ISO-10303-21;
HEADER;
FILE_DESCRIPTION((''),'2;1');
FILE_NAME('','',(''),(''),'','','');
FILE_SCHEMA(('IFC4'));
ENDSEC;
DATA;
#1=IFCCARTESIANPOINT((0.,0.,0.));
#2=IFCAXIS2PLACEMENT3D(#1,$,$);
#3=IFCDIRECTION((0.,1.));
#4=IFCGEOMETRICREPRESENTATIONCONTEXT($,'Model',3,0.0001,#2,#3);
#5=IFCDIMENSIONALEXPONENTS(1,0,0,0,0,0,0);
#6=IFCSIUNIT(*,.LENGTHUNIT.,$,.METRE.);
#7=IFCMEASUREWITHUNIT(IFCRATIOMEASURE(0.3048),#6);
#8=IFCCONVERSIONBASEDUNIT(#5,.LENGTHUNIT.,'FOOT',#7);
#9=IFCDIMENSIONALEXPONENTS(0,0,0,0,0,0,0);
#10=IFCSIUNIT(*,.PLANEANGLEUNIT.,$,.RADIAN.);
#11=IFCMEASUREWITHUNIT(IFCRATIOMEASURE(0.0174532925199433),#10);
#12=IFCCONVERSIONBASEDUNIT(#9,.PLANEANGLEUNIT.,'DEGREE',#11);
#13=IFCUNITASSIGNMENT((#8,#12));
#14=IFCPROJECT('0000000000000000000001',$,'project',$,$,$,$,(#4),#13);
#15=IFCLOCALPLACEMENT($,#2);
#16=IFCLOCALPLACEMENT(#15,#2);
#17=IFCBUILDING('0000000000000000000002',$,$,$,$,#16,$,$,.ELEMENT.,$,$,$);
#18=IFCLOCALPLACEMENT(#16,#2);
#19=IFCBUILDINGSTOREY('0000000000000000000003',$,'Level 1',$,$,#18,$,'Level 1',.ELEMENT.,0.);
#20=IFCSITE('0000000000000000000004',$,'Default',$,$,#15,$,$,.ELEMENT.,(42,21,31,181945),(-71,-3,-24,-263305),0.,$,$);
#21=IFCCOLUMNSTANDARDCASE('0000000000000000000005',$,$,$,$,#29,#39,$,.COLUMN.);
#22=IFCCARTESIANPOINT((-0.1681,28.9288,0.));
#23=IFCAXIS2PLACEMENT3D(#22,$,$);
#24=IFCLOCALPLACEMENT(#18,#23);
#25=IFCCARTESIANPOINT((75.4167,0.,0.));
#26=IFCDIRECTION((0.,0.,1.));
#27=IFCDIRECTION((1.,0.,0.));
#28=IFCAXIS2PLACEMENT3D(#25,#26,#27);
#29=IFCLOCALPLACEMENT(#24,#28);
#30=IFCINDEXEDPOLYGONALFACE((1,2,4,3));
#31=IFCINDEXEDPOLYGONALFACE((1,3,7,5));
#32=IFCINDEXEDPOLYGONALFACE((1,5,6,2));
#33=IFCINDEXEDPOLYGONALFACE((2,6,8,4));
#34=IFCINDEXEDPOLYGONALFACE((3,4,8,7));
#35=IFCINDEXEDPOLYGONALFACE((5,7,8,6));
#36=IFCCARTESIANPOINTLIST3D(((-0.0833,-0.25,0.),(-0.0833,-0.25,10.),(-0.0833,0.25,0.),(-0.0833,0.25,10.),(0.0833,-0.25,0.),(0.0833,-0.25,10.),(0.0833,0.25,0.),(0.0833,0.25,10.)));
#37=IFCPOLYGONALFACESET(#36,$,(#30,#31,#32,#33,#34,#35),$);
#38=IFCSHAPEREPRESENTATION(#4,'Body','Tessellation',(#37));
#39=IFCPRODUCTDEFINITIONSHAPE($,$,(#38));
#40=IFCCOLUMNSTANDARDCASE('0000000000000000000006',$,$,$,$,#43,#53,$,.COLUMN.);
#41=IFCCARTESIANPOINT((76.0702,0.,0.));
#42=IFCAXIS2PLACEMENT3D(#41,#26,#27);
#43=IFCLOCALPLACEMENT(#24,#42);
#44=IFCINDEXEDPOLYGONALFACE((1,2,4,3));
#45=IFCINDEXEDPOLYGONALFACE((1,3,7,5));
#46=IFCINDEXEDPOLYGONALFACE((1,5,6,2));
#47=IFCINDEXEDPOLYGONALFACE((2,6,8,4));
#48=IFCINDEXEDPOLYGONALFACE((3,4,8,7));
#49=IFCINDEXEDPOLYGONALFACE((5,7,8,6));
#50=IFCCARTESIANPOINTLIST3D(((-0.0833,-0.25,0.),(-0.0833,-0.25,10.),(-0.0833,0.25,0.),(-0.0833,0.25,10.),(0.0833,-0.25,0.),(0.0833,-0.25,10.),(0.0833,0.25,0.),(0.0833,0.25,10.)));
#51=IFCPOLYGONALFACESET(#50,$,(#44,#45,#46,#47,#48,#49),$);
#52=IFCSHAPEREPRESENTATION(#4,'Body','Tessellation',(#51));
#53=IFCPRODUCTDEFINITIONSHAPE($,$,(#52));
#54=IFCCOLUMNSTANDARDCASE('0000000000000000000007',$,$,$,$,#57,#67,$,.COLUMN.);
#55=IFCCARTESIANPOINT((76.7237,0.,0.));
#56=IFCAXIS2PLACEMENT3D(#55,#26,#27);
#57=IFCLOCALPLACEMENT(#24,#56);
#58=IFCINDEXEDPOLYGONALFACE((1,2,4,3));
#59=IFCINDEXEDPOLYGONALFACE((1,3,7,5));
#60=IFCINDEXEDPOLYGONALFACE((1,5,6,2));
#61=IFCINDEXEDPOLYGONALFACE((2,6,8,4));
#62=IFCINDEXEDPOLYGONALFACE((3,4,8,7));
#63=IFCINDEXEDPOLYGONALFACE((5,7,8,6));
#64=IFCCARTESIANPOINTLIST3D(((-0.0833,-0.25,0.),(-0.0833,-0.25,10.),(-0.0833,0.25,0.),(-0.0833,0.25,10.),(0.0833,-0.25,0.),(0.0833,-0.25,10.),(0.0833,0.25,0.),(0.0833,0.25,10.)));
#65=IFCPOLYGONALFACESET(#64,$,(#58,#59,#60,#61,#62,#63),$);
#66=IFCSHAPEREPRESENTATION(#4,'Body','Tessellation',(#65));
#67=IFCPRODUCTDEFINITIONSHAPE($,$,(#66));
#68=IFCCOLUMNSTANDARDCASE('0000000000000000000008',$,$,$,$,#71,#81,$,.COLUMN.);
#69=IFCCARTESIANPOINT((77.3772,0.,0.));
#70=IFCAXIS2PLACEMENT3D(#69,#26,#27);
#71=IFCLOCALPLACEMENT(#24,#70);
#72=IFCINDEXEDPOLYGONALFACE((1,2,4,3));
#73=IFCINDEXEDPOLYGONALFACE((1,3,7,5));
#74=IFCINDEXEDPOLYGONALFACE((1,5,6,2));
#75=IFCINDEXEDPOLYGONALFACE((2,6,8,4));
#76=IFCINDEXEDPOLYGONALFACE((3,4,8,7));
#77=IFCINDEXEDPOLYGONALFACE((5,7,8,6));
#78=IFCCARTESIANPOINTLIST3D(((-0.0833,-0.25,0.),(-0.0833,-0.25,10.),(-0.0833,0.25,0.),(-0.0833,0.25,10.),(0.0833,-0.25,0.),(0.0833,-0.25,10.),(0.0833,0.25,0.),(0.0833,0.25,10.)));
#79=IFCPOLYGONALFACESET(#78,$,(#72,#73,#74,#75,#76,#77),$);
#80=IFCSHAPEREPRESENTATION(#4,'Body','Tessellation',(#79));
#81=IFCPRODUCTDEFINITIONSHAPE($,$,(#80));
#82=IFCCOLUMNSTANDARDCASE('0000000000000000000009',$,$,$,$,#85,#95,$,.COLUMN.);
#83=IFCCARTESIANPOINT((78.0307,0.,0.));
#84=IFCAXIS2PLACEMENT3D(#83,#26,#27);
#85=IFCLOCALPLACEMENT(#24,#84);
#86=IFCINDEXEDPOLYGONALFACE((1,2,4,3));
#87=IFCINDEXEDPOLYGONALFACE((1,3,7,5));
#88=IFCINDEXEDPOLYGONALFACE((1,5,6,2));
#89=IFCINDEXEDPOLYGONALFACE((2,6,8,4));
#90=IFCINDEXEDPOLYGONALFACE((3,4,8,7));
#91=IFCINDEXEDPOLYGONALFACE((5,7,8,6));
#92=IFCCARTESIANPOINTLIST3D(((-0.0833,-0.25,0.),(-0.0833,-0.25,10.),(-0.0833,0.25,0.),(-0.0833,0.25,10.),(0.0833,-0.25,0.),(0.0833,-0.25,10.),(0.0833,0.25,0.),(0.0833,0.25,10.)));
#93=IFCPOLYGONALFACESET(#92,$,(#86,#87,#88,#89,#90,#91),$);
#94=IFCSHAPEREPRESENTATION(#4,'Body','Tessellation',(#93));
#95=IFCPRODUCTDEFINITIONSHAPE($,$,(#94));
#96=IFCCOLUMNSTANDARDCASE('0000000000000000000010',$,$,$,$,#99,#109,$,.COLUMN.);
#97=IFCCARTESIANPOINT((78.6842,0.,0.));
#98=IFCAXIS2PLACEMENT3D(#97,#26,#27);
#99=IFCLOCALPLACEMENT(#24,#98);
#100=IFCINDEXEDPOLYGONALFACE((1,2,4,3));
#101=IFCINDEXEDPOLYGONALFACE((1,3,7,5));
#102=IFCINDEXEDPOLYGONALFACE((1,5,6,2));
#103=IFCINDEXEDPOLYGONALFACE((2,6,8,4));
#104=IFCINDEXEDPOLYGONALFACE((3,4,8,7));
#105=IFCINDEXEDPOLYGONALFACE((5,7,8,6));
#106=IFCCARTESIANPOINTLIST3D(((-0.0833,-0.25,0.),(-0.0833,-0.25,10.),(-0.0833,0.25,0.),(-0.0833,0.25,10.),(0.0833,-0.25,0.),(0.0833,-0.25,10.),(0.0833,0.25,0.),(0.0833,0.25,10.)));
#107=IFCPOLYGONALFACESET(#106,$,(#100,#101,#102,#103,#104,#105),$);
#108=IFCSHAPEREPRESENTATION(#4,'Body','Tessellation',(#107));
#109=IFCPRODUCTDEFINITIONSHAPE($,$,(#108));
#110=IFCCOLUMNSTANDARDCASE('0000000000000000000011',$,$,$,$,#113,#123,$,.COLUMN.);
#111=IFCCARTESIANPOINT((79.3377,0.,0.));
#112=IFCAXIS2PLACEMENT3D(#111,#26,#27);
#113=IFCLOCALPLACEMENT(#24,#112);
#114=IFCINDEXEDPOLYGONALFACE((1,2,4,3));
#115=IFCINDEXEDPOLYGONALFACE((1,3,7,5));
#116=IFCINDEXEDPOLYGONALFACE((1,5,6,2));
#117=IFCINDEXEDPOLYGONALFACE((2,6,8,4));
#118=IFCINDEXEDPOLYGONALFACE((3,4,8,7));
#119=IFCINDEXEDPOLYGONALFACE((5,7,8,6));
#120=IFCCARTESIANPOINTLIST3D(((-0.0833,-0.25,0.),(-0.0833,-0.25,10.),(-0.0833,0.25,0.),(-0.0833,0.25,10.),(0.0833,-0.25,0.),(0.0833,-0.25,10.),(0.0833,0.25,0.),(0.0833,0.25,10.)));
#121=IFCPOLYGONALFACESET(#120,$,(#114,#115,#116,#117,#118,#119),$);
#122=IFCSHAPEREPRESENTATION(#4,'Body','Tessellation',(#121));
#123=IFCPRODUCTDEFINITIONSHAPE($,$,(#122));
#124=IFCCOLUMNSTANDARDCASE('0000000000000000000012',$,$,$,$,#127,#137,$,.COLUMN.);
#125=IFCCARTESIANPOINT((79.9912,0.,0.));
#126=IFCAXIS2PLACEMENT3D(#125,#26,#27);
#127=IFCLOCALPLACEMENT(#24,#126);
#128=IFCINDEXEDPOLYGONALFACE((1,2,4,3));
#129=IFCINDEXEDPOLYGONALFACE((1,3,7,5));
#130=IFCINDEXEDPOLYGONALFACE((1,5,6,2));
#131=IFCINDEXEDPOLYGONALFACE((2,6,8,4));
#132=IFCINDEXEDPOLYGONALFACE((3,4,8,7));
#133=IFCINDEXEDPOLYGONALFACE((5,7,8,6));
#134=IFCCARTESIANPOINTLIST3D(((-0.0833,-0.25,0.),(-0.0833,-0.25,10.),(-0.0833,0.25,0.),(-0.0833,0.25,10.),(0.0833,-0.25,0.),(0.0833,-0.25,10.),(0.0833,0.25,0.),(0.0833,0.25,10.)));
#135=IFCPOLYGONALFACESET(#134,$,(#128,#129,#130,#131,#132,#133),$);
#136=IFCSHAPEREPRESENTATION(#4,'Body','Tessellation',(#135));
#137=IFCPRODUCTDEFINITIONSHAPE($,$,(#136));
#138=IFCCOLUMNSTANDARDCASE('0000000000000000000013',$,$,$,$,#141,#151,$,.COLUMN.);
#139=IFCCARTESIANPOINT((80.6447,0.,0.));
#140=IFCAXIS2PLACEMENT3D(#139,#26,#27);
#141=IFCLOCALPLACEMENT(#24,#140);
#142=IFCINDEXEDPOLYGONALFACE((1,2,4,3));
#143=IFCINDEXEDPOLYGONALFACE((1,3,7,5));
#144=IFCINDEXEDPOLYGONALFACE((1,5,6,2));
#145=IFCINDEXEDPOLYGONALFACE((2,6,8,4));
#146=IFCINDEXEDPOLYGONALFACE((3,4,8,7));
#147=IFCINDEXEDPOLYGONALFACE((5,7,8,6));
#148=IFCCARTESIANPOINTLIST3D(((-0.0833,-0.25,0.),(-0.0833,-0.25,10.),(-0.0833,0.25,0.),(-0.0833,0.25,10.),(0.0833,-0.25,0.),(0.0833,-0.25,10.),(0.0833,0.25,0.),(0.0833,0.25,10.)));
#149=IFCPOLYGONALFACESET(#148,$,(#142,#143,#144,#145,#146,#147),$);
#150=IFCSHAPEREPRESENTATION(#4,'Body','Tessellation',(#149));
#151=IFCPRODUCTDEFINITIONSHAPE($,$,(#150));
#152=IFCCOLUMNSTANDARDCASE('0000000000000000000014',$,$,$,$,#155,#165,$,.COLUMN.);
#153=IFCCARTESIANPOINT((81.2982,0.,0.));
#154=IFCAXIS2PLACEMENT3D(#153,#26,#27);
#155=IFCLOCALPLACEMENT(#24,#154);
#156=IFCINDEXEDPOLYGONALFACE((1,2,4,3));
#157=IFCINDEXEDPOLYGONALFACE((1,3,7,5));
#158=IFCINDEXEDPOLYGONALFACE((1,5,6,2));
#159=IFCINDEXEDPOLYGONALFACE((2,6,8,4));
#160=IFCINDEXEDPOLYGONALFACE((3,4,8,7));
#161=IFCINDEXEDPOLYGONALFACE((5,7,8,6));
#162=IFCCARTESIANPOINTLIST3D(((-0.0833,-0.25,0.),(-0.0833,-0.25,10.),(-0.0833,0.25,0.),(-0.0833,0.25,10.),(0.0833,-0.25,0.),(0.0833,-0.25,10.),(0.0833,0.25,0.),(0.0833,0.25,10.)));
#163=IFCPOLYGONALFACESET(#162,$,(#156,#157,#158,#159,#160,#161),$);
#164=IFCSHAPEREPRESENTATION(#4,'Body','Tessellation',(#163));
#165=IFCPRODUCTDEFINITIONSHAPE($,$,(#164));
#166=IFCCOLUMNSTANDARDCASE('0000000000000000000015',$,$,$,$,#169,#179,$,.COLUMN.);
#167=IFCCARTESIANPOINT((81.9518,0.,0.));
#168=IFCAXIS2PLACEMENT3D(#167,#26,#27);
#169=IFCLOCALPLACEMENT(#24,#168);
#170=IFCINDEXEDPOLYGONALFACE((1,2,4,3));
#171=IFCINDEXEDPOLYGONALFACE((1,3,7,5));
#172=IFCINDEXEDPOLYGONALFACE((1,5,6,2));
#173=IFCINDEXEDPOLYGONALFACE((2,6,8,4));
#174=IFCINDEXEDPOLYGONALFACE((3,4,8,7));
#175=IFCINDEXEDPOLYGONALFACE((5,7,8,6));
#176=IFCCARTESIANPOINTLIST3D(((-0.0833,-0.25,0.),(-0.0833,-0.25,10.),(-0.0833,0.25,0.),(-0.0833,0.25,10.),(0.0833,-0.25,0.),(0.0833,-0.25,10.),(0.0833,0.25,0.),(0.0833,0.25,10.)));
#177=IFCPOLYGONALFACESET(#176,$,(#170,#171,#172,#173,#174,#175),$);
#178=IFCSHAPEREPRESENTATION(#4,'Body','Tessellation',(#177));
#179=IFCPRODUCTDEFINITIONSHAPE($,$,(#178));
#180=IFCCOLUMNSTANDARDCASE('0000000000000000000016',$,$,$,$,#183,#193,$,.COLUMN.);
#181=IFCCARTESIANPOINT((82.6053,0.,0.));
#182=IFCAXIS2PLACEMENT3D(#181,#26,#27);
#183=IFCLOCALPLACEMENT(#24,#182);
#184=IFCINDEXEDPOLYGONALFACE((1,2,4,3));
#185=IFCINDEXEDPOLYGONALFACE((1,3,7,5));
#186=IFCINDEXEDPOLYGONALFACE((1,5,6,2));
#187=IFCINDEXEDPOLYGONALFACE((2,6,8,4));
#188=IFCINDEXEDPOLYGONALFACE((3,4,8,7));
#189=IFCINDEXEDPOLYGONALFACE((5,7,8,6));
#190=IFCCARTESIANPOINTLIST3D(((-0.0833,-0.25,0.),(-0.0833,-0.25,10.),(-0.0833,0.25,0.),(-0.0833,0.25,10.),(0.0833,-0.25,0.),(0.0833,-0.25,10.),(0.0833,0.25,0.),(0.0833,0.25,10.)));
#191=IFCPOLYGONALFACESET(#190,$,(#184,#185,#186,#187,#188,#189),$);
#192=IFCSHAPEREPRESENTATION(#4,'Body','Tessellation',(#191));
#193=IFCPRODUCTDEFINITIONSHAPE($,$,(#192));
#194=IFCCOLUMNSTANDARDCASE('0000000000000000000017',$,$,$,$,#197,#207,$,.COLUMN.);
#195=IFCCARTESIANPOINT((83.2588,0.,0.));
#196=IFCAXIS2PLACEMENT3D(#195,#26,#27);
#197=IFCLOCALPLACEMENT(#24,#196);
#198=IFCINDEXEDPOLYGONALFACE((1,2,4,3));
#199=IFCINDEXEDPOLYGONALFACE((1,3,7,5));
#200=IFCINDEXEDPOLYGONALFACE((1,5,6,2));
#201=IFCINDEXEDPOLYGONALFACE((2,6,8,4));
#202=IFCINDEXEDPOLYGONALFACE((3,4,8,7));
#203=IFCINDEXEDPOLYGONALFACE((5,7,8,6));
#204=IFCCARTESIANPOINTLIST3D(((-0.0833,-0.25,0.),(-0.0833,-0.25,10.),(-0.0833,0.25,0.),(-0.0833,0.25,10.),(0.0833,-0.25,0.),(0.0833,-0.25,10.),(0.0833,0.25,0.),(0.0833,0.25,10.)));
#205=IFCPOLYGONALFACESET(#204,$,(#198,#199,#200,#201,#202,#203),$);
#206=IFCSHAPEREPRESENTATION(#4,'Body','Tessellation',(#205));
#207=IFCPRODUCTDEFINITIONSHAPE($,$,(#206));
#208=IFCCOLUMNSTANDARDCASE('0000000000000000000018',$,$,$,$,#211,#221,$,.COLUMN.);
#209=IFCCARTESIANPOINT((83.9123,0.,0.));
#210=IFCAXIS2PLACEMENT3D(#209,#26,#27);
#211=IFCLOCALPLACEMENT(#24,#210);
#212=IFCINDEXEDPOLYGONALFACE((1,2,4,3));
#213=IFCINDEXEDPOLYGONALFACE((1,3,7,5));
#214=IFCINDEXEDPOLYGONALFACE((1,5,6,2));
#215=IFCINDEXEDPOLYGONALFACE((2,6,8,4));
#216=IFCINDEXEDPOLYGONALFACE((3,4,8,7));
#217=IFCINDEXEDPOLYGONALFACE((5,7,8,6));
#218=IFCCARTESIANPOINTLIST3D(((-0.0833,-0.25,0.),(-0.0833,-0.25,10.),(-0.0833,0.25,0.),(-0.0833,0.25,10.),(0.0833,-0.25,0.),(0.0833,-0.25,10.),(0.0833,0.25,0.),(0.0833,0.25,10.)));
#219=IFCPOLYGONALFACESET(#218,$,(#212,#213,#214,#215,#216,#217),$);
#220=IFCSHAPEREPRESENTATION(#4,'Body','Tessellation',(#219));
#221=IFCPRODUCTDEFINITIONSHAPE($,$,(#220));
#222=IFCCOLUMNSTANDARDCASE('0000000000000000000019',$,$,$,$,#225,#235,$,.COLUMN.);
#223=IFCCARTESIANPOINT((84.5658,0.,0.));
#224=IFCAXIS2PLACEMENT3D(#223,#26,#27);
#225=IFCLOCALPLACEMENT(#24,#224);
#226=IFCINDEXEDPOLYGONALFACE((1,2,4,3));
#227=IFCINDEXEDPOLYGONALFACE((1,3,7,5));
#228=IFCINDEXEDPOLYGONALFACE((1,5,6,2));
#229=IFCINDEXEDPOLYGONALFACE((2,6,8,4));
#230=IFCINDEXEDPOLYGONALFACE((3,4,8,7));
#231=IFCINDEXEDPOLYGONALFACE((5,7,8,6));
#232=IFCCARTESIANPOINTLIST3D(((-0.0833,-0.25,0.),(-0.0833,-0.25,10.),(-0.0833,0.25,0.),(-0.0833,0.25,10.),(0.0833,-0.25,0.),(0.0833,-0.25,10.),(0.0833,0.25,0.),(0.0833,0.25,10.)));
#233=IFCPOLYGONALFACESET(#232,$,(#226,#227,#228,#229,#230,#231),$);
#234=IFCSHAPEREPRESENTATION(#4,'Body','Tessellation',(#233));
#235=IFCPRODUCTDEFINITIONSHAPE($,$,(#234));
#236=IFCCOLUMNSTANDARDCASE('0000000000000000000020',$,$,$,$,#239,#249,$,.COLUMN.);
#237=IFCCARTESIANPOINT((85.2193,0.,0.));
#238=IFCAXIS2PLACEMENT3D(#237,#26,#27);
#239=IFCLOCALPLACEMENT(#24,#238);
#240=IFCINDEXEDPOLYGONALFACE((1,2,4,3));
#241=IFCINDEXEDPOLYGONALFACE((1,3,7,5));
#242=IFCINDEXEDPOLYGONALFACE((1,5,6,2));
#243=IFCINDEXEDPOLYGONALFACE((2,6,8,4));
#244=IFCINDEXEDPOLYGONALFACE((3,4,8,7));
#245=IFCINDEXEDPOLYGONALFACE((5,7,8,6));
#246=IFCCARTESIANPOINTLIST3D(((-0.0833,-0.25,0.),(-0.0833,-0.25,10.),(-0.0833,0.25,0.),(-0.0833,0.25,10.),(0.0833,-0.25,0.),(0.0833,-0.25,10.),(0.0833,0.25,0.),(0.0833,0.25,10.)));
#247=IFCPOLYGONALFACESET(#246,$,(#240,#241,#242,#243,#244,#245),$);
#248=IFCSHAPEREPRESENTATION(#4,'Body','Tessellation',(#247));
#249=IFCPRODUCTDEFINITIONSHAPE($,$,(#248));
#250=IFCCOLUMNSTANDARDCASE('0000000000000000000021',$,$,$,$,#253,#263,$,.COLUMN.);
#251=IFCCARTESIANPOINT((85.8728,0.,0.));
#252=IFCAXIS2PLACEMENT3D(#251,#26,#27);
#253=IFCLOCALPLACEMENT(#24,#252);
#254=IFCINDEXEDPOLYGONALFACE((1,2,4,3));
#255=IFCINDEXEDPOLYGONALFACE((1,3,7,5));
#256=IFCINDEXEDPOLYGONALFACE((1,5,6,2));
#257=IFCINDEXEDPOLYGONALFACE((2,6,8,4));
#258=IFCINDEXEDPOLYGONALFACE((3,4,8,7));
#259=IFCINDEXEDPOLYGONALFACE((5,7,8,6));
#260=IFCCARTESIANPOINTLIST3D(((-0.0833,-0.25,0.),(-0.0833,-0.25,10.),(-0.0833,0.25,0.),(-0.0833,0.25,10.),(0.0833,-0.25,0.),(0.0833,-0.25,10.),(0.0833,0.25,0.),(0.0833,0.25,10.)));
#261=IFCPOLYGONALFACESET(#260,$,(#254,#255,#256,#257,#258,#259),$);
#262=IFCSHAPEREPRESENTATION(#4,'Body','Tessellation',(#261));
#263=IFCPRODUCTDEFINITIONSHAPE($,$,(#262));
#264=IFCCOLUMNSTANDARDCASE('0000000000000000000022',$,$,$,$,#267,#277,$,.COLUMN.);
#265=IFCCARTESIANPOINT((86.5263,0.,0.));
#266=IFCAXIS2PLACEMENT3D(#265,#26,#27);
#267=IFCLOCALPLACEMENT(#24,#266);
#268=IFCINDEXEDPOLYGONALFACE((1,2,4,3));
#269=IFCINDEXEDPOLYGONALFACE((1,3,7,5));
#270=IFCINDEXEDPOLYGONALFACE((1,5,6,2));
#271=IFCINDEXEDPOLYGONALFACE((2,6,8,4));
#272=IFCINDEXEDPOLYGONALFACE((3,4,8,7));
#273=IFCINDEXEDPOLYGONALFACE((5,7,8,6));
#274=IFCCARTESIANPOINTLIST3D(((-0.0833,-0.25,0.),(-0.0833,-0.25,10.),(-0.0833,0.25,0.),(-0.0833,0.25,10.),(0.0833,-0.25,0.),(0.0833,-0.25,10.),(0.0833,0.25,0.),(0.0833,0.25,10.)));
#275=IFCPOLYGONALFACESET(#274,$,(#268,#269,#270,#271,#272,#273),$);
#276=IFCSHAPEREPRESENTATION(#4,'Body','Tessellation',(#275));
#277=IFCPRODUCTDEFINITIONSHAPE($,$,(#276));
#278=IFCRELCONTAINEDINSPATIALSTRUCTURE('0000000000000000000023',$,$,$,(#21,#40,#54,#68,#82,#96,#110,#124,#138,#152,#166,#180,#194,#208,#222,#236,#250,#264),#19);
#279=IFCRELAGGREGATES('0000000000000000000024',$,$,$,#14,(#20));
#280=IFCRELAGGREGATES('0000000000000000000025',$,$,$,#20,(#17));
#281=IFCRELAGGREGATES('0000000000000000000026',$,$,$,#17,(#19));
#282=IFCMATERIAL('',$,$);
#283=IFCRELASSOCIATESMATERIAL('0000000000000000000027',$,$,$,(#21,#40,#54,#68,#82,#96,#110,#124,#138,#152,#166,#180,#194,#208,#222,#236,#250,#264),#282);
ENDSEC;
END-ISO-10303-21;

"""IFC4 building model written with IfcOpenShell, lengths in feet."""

from ifc_helpers import new_model, entity, si_unit, converted_unit, direction, frame, origin, place, context, project, spatial, rectangle, extrude, material, element, save


model = new_model("IFC4")

# Units and contexts
model_context = context("Model", 3, precision=0.0001, world=origin(), true_north=direction((0.0, 1.0)))
ifc_project = project(units=[converted_unit("LENGTHUNIT", "FOOT", entity("IfcRatioMeasure", 0.3048), si_unit("LENGTHUNIT", "METRE"), dimensions=[1, 0, 0, 0, 0, 0, 0]), converted_unit("PLANEANGLEUNIT", "DEGREE", entity("IfcRatioMeasure", 0.0174532925199433), si_unit("PLANEANGLEUNIT", "RADIAN"), dimensions=[0, 0, 0, 0, 0, 0, 0])], contexts=[model_context])

# Site, building, storey
site_placement = place(None, origin())
site = spatial("IfcSite", under=ifc_project, at=site_placement, Name="Default", CompositionType="ELEMENT", RefLatitude=(42, 21, 31, 181945), RefLongitude=(-71, -3, -24, -263305), RefElevation=0.0)
building_placement = place(site_placement, origin())
building = spatial("IfcBuilding", under=site, at=building_placement, CompositionType="ELEMENT")
storey_placement = place(building_placement, origin())
storey = spatial("IfcBuildingStorey", under=building, at=storey_placement, Name="Level 1", LongName="Level 1", CompositionType="ELEMENT", Elevation=0.0)

# Columns
ifc_material_1 = material(Name="")
placement = place(storey_placement, frame((-0.1681, 28.9288, 0.0)))
for number, where, z_axis, x_axis in (
    (1, (75.4167, 0.0, 0.0), (0.0, 0.0, 1.0), (1.0, 0.0, 0.0)),
    (2, (76.0702, 0.0, 0.0), (0.0, 0.0, 1.0), (1.0, 0.0, 0.0)),
    (3, (76.7237, 0.0, 0.0), (0.0, 0.0, 1.0), (1.0, 0.0, 0.0)),
    (4, (77.3772, 0.0, 0.0), (0.0, 0.0, 1.0), (1.0, 0.0, 0.0)),
    (5, (78.0307, 0.0, 0.0), (0.0, 0.0, 1.0), (1.0, 0.0, 0.0)),
    (6, (78.6842, 0.0, 0.0), (0.0, 0.0, 1.0), (1.0, 0.0, 0.0)),
    (7, (79.3377, 0.0, 0.0), (0.0, 0.0, 1.0), (1.0, 0.0, 0.0)),
    (8, (79.9912, 0.0, 0.0), (0.0, 0.0, 1.0), (1.0, 0.0, 0.0)),
    (9, (80.6447, 0.0, 0.0), (0.0, 0.0, 1.0), (1.0, 0.0, 0.0)),
    (10, (81.2982, 0.0, 0.0), (0.0, 0.0, 1.0), (1.0, 0.0, 0.0)),
    (11, (81.9518, 0.0, 0.0), (0.0, 0.0, 1.0), (1.0, 0.0, 0.0)),
    (12, (82.6053, 0.0, 0.0), (0.0, 0.0, 1.0), (1.0, 0.0, 0.0)),
    (13, (83.2588, 0.0, 0.0), (0.0, 0.0, 1.0), (1.0, 0.0, 0.0)),
    (14, (83.9123, 0.0, 0.0), (0.0, 0.0, 1.0), (1.0, 0.0, 0.0)),
    (15, (84.5658, 0.0, 0.0), (0.0, 0.0, 1.0), (1.0, 0.0, 0.0)),
    (16, (85.2193, 0.0, 0.0), (0.0, 0.0, 1.0), (1.0, 0.0, 0.0)),
    (17, (85.8728, 0.0, 0.0), (0.0, 0.0, 1.0), (1.0, 0.0, 0.0)),
    (18, (86.5263, 0.0, 0.0), (0.0, 0.0, 1.0), (1.0, 0.0, 0.0)),
):
    element("IfcColumnStandardCase", number, at=place(placement, frame(where, z_axis=z_axis, x_axis=x_axis)), inside=storey, material=ifc_material_1, PredefinedType="COLUMN", context=model_context, shape_type="SweptSolid", body=[
        extrude(rectangle(XDim=0.1667, YDim=0.5), origin(), (0.0, 0.0, 1.0), 10.0),
    ])

save(model, "model.ifc")
